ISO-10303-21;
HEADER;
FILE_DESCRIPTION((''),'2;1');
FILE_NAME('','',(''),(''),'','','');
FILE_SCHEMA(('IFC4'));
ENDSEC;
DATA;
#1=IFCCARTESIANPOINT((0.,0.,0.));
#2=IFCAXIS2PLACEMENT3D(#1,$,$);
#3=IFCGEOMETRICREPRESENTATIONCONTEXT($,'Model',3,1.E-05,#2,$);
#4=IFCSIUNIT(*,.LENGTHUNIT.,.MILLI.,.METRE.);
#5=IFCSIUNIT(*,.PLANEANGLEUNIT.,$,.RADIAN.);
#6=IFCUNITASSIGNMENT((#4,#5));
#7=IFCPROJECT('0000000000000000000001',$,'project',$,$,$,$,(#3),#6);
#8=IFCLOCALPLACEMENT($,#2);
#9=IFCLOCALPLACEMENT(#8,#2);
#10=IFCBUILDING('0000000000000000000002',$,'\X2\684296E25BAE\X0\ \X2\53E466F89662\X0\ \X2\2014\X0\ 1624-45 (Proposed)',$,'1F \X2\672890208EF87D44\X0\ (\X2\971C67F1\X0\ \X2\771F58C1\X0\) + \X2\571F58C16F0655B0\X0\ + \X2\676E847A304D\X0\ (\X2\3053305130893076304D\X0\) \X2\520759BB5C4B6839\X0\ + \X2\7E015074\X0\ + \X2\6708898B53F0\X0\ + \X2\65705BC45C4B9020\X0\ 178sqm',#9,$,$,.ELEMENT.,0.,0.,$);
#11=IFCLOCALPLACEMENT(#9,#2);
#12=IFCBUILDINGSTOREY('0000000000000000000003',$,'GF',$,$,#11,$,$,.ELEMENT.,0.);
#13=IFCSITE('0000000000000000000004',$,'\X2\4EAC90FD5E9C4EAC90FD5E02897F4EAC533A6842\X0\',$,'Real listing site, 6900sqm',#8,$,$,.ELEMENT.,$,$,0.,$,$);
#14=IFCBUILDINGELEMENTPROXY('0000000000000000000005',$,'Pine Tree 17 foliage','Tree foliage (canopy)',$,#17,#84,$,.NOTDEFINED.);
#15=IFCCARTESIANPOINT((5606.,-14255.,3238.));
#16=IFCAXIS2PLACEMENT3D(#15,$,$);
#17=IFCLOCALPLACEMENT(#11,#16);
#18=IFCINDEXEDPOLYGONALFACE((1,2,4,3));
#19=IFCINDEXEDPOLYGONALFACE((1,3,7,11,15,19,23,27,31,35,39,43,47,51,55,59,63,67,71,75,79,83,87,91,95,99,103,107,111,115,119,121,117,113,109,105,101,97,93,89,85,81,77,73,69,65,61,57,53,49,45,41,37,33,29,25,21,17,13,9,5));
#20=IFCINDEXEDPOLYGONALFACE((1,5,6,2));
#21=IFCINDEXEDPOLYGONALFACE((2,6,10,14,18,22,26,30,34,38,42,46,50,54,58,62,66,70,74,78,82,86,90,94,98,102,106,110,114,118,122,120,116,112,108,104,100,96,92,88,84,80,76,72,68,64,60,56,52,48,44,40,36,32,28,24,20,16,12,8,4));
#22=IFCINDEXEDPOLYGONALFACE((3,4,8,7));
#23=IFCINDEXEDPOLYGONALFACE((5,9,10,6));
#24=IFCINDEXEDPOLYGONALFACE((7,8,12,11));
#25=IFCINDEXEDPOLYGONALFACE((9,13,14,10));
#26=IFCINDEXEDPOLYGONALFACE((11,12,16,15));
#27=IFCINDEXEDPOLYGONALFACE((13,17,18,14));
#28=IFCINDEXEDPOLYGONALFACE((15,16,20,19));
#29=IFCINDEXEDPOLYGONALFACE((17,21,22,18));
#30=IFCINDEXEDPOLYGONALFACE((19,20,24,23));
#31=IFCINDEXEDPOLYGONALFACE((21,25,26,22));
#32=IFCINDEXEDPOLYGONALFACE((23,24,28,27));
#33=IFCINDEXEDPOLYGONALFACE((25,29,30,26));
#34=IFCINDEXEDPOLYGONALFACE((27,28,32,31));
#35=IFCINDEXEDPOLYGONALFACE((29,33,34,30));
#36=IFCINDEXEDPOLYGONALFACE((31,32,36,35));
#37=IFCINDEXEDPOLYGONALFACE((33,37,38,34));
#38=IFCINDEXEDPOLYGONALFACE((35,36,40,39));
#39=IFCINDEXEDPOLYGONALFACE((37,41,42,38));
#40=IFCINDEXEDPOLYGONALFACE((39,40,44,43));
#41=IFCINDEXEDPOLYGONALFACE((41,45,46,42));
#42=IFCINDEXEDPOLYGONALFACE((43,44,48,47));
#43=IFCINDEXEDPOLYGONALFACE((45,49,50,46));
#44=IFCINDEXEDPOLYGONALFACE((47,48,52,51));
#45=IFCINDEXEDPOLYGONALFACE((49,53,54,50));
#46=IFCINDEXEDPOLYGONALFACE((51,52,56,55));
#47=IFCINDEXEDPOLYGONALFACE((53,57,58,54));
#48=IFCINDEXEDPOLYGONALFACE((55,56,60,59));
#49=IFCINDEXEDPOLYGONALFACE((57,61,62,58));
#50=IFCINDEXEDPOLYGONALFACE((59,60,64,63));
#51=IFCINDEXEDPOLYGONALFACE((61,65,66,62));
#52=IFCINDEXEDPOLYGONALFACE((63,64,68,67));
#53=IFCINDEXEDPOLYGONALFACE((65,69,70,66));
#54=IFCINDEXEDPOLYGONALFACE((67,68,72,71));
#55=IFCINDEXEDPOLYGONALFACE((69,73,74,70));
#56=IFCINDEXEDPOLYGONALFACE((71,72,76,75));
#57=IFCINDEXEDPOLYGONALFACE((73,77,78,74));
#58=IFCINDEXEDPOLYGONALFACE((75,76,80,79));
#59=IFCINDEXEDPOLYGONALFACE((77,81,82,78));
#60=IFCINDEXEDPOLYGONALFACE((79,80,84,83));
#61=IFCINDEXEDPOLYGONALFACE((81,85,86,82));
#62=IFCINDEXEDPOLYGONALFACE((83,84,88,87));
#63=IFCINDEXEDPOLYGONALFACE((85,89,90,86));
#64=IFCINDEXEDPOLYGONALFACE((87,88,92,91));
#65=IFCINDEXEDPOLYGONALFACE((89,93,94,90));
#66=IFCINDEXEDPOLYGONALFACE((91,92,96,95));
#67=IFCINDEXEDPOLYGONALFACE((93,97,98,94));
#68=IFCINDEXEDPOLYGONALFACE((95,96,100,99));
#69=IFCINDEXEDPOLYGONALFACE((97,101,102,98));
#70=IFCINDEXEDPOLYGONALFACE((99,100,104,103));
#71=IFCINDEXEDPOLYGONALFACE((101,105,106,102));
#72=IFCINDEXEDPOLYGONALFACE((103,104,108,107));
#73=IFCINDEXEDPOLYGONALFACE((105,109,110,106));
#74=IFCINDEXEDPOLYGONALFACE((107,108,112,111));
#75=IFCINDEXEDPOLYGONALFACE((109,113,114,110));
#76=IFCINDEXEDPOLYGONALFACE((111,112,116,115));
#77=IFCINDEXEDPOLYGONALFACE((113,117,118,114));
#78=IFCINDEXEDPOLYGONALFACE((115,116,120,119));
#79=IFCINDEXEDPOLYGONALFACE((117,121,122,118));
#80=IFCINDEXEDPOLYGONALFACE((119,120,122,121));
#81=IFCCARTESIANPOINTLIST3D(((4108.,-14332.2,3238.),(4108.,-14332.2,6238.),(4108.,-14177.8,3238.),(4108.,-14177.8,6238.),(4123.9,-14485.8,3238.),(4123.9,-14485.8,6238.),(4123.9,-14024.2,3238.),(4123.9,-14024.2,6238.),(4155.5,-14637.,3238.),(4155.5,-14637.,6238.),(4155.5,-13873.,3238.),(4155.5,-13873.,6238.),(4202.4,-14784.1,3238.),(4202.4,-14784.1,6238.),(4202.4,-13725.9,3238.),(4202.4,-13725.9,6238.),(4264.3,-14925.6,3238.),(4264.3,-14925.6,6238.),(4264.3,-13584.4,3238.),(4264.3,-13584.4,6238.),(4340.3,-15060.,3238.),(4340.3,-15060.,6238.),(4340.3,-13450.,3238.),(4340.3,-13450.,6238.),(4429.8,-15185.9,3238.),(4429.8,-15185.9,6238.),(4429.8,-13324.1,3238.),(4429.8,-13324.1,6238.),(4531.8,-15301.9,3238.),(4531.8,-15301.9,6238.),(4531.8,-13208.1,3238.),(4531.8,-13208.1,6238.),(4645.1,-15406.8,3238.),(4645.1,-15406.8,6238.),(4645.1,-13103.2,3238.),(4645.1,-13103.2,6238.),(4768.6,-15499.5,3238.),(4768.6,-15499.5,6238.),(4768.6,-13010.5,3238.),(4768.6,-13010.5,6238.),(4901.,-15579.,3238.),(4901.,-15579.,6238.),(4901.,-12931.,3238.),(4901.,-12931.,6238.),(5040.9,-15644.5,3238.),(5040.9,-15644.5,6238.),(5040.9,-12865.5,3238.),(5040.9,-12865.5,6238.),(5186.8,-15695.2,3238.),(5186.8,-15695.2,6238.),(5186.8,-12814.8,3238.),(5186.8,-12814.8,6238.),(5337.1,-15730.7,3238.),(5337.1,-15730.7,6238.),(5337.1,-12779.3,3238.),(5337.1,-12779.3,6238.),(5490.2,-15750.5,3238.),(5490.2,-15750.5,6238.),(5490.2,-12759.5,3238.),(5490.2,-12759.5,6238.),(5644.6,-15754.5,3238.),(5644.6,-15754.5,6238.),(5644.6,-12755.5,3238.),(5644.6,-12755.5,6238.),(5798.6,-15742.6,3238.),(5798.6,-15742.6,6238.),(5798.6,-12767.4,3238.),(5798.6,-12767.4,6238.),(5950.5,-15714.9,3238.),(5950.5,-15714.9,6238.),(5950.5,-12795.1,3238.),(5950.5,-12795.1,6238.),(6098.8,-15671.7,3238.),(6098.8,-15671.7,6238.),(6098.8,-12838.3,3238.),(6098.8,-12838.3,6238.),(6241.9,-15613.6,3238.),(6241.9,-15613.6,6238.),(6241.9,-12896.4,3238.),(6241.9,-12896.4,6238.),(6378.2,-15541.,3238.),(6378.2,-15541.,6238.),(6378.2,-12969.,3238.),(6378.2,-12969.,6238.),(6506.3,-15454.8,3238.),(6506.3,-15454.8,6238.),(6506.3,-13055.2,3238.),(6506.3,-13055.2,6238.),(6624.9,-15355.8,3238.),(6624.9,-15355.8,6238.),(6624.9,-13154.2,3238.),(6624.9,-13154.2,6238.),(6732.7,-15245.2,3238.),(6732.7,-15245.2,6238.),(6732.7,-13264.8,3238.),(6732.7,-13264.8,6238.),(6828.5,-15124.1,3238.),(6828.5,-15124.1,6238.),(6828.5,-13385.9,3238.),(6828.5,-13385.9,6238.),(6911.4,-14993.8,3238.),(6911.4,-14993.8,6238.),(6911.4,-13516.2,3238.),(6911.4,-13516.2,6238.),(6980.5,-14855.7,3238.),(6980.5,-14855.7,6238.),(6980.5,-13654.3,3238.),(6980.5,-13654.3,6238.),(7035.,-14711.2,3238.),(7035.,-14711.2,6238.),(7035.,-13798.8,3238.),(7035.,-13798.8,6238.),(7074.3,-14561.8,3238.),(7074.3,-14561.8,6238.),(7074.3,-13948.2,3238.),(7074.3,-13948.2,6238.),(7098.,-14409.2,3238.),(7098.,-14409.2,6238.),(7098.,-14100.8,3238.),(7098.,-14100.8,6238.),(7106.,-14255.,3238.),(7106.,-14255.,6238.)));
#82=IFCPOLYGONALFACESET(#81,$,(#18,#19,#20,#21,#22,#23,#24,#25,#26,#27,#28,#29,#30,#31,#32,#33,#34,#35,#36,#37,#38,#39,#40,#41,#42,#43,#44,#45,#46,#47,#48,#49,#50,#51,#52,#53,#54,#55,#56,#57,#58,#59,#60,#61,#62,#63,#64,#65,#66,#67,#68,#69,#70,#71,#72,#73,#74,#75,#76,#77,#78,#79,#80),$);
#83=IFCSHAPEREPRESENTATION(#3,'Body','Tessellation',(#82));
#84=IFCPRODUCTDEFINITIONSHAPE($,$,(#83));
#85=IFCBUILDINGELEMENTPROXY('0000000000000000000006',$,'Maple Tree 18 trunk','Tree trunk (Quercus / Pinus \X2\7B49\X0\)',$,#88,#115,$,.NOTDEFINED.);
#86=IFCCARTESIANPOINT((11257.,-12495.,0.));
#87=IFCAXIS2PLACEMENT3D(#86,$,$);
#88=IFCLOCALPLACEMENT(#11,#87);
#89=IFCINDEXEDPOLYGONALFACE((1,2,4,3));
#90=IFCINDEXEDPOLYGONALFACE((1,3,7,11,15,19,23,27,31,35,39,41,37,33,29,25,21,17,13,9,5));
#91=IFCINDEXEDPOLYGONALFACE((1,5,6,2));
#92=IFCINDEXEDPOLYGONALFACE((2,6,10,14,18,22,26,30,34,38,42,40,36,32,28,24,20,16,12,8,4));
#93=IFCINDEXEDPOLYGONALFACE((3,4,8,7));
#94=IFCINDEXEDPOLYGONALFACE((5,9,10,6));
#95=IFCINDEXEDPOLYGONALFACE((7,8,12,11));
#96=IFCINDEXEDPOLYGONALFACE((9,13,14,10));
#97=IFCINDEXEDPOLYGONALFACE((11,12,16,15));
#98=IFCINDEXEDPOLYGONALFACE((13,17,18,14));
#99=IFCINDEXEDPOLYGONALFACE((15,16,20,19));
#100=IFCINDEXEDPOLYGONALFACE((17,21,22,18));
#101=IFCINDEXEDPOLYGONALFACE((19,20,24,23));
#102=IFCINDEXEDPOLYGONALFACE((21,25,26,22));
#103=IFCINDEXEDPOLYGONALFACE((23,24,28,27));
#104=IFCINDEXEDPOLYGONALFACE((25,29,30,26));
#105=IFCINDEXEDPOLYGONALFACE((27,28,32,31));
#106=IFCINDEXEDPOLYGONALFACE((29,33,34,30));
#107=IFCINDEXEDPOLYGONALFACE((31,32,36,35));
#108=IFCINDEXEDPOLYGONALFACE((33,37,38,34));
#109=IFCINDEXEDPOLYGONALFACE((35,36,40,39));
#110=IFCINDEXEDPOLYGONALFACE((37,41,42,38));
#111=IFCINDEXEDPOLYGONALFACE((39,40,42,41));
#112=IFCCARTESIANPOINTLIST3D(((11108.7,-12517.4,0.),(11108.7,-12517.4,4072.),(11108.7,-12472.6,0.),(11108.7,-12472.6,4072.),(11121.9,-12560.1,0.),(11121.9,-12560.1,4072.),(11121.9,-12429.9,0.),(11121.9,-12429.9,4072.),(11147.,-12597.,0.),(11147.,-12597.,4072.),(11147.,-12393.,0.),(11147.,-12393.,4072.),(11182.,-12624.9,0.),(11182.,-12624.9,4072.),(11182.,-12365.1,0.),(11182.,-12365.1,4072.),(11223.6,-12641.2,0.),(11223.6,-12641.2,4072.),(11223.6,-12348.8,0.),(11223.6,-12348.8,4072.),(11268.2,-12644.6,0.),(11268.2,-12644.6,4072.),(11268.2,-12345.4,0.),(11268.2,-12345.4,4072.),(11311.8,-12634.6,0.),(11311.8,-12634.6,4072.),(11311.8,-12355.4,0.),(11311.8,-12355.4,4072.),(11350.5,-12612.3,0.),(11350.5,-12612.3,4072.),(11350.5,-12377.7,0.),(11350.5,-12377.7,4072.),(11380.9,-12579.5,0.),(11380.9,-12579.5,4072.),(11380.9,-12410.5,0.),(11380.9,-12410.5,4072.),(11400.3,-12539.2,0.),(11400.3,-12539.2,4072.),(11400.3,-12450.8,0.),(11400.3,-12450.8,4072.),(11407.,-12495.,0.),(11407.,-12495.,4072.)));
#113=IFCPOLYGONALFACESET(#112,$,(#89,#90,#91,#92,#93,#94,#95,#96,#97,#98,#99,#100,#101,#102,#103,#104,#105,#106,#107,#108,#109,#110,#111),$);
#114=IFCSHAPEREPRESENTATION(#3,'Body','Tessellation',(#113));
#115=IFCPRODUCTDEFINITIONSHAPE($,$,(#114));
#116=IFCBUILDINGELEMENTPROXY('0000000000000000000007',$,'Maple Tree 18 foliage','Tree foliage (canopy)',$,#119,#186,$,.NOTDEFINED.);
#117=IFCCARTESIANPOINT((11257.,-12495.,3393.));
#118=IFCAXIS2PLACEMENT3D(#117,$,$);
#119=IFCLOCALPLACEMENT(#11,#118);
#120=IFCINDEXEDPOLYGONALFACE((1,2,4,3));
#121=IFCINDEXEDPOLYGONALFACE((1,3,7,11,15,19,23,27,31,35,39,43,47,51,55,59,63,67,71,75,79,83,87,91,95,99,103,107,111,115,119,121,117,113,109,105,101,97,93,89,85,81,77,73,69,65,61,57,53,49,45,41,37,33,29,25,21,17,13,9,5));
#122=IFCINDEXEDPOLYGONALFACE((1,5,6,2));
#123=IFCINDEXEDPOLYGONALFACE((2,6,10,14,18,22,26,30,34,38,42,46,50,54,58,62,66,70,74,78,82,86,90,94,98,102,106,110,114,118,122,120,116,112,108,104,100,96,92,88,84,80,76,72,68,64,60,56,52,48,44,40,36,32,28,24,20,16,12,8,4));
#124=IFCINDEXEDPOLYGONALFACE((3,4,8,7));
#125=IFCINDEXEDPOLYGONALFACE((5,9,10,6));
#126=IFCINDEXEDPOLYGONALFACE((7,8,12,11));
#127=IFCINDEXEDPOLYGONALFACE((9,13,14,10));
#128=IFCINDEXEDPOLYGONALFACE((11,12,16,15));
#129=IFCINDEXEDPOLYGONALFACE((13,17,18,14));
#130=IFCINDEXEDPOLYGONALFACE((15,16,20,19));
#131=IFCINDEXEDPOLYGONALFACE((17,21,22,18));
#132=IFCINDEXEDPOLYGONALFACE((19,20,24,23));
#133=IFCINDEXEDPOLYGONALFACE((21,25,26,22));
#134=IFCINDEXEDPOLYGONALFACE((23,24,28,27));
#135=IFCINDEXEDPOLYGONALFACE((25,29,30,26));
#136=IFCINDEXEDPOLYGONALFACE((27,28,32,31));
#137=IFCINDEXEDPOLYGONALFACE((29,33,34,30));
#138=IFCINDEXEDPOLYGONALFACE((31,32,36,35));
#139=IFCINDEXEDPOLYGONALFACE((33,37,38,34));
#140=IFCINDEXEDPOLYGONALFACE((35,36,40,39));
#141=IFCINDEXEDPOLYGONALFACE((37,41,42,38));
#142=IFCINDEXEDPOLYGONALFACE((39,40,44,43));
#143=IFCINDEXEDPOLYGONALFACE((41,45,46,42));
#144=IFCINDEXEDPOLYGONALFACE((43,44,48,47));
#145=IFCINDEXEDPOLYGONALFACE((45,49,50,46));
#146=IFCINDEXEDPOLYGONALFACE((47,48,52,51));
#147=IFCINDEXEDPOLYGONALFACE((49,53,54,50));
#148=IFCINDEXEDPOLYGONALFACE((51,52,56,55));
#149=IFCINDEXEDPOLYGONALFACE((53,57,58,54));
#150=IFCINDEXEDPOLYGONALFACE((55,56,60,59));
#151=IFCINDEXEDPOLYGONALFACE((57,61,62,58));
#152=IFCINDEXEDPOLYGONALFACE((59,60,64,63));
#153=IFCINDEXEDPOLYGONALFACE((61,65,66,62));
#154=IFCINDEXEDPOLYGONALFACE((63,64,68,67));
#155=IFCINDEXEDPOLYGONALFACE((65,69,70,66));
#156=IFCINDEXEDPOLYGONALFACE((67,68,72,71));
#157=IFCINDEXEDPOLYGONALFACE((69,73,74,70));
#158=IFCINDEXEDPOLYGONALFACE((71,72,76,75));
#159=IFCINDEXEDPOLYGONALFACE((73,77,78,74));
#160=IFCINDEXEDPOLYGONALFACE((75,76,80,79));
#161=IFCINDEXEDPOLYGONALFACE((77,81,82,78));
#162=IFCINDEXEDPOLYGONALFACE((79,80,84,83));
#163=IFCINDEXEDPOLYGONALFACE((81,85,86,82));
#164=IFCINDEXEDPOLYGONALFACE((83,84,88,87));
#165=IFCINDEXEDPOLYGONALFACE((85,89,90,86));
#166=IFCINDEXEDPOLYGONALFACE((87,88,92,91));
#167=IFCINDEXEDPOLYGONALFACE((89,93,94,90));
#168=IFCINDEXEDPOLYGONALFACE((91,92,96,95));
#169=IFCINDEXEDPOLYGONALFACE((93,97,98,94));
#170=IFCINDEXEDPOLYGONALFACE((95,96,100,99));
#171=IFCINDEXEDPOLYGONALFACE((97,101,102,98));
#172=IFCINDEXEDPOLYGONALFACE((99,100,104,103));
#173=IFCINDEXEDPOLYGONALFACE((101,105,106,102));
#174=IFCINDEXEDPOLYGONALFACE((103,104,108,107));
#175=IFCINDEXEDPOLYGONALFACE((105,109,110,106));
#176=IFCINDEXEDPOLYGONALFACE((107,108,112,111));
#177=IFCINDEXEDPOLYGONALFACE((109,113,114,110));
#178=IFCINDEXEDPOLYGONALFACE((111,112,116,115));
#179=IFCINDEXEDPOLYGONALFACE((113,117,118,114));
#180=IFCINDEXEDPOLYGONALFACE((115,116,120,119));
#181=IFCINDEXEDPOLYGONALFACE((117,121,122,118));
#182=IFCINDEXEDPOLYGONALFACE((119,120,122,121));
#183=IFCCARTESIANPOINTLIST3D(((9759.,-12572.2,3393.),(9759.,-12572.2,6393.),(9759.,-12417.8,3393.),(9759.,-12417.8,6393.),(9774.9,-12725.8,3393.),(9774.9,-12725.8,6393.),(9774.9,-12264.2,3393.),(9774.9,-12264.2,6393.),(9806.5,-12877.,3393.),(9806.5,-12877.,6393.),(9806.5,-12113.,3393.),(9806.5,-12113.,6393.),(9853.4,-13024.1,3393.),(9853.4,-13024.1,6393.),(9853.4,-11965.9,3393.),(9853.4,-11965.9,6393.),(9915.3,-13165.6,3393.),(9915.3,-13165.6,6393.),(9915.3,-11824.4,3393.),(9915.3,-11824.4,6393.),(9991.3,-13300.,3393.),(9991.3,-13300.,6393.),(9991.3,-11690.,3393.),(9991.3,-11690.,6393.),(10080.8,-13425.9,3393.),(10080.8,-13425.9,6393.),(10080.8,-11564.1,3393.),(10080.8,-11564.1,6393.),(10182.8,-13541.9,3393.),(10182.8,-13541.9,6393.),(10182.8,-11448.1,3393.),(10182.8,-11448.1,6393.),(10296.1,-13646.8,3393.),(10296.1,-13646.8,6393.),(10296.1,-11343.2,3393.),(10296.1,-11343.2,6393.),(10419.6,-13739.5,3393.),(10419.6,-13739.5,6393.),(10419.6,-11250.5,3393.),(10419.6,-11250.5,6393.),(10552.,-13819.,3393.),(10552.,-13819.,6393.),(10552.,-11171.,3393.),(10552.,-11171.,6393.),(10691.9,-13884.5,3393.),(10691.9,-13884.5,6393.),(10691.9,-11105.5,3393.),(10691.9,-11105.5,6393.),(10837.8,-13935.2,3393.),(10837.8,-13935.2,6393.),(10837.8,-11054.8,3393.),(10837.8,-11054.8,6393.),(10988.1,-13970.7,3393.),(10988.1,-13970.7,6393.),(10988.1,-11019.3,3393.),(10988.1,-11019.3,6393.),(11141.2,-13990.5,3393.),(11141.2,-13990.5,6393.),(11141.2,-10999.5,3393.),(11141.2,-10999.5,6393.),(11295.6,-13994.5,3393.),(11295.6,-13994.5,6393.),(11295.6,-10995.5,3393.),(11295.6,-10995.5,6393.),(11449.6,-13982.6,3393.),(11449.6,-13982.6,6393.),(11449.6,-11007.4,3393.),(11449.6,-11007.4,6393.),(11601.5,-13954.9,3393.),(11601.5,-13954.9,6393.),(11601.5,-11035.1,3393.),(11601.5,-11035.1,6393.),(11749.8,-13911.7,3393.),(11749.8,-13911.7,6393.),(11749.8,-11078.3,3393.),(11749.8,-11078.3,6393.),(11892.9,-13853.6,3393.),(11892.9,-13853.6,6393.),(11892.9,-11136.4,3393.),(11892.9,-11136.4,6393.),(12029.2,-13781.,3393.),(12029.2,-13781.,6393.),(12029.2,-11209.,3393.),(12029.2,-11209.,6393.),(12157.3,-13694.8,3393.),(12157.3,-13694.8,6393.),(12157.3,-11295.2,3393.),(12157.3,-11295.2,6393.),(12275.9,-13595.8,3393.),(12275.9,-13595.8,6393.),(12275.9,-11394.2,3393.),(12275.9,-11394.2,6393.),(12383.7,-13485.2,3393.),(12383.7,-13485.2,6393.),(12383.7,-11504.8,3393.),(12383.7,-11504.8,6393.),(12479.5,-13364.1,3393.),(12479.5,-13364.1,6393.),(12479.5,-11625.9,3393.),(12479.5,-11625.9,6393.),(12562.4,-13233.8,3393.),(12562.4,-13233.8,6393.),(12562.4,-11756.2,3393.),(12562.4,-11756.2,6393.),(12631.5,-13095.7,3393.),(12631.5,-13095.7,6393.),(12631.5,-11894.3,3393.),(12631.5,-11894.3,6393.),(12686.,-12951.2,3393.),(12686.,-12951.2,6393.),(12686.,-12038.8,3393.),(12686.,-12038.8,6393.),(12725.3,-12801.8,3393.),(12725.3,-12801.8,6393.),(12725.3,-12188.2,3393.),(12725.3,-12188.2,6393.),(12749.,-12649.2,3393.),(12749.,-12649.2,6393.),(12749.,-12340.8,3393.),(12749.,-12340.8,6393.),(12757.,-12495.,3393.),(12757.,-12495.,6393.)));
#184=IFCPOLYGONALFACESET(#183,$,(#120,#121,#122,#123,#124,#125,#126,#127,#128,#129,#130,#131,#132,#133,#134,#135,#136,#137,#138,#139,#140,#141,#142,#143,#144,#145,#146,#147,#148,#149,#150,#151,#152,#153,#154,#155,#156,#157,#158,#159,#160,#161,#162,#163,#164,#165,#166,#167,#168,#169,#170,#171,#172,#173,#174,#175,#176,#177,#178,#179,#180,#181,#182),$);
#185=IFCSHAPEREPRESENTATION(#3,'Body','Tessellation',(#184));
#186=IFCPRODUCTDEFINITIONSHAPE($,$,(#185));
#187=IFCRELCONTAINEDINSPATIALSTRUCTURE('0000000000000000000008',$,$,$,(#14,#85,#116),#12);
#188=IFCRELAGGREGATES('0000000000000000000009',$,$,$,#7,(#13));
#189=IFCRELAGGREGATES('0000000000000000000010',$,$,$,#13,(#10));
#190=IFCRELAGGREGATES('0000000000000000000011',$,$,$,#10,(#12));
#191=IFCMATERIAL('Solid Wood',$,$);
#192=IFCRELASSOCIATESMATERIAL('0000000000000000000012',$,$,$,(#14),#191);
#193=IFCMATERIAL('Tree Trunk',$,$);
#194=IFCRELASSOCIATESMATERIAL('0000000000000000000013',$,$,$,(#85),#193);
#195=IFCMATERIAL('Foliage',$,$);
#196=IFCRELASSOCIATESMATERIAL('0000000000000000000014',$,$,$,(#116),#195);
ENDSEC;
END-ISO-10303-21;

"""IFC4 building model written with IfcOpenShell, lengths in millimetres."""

from ifc_helpers import new_model, si_unit, frame, origin, origin_2d, place, context, project, spatial, circle, extrude, material, element, save


model = new_model("IFC4")

# Units and contexts
model_context = context("Model", 3, precision=1e-05, world=origin())
ifc_project = project(units=[si_unit("LENGTHUNIT", "METRE", prefix="MILLI"), si_unit("PLANEANGLEUNIT", "RADIAN")], contexts=[model_context])

# Site, building, storey
site_placement = place(None, origin())
site = spatial("IfcSite", under=ifc_project, at=site_placement, Name="京都府京都市西京区桂", ObjectType="Real listing site, 6900sqm", CompositionType="ELEMENT", RefElevation=0.0)
building_placement = place(site_placement, origin())
building = spatial("IfcBuilding", under=site, at=building_placement, Name="桂離宮 古書院 — 1624-45 (Proposed)", ObjectType="1F 木造軸組 (霜柱 真壁) + 土壁漆喰 + 杮葺き (こけらぶき) 切妻屋根 + 縁側 + 月見台 + 数寄屋造 178sqm", CompositionType="ELEMENT", ElevationOfRefHeight=0.0, ElevationOfTerrain=0.0)
storey_placement = place(building_placement, origin())
storey = spatial("IfcBuildingStorey", under=building, at=storey_placement, Name="GF", CompositionType="ELEMENT", Elevation=0.0)

# Shared definitions
ifc_material_1 = material(Name="Solid Wood")

# Building element proxies
proxy_1_placement = place(storey_placement, frame((5606.0, -14255.0, 3238.0)))
element("IfcBuildingElementProxy", 1, at=proxy_1_placement, inside=storey, material=ifc_material_1, Name="Pine Tree 17 foliage", Description="Tree foliage (canopy)", PredefinedType="NOTDEFINED", context=model_context, shape_type="SweptSolid", body=[
    extrude(circle(Radius=1500.0, at=origin_2d()), frame((5606.0, -14255.0, 3238.0)), (0.0, 0.0, 1.0), 3000.0),
])
ifc_material_2 = material(Name="Tree Trunk")
proxy_2_placement = place(storey_placement, frame((11257.0, -12495.0, 0.0)))
element("IfcBuildingElementProxy", 2, at=proxy_2_placement, inside=storey, material=ifc_material_2, Name="Maple Tree 18 trunk", Description="Tree trunk (Quercus / Pinus 等)", PredefinedType="NOTDEFINED", context=model_context, shape_type="SweptSolid", body=[
    extrude(circle(Radius=150.0, at=origin_2d()), frame((11257.0, -12495.0, 0.0)), (0.0, 0.0, 1.0), 4072.0),
])
ifc_material_3 = material(Name="Foliage")
proxy_3_placement = place(storey_placement, frame((11257.0, -12495.0, 3393.0)))
element("IfcBuildingElementProxy", 3, at=proxy_3_placement, inside=storey, material=ifc_material_3, Name="Maple Tree 18 foliage", Description="Tree foliage (canopy)", PredefinedType="NOTDEFINED", context=model_context, shape_type="SweptSolid", body=[
    extrude(circle(Radius=1500.0, at=origin_2d()), frame((11257.0, -12495.0, 3393.0)), (0.0, 0.0, 1.0), 3000.0),
])

save(model, "model.ifc")
